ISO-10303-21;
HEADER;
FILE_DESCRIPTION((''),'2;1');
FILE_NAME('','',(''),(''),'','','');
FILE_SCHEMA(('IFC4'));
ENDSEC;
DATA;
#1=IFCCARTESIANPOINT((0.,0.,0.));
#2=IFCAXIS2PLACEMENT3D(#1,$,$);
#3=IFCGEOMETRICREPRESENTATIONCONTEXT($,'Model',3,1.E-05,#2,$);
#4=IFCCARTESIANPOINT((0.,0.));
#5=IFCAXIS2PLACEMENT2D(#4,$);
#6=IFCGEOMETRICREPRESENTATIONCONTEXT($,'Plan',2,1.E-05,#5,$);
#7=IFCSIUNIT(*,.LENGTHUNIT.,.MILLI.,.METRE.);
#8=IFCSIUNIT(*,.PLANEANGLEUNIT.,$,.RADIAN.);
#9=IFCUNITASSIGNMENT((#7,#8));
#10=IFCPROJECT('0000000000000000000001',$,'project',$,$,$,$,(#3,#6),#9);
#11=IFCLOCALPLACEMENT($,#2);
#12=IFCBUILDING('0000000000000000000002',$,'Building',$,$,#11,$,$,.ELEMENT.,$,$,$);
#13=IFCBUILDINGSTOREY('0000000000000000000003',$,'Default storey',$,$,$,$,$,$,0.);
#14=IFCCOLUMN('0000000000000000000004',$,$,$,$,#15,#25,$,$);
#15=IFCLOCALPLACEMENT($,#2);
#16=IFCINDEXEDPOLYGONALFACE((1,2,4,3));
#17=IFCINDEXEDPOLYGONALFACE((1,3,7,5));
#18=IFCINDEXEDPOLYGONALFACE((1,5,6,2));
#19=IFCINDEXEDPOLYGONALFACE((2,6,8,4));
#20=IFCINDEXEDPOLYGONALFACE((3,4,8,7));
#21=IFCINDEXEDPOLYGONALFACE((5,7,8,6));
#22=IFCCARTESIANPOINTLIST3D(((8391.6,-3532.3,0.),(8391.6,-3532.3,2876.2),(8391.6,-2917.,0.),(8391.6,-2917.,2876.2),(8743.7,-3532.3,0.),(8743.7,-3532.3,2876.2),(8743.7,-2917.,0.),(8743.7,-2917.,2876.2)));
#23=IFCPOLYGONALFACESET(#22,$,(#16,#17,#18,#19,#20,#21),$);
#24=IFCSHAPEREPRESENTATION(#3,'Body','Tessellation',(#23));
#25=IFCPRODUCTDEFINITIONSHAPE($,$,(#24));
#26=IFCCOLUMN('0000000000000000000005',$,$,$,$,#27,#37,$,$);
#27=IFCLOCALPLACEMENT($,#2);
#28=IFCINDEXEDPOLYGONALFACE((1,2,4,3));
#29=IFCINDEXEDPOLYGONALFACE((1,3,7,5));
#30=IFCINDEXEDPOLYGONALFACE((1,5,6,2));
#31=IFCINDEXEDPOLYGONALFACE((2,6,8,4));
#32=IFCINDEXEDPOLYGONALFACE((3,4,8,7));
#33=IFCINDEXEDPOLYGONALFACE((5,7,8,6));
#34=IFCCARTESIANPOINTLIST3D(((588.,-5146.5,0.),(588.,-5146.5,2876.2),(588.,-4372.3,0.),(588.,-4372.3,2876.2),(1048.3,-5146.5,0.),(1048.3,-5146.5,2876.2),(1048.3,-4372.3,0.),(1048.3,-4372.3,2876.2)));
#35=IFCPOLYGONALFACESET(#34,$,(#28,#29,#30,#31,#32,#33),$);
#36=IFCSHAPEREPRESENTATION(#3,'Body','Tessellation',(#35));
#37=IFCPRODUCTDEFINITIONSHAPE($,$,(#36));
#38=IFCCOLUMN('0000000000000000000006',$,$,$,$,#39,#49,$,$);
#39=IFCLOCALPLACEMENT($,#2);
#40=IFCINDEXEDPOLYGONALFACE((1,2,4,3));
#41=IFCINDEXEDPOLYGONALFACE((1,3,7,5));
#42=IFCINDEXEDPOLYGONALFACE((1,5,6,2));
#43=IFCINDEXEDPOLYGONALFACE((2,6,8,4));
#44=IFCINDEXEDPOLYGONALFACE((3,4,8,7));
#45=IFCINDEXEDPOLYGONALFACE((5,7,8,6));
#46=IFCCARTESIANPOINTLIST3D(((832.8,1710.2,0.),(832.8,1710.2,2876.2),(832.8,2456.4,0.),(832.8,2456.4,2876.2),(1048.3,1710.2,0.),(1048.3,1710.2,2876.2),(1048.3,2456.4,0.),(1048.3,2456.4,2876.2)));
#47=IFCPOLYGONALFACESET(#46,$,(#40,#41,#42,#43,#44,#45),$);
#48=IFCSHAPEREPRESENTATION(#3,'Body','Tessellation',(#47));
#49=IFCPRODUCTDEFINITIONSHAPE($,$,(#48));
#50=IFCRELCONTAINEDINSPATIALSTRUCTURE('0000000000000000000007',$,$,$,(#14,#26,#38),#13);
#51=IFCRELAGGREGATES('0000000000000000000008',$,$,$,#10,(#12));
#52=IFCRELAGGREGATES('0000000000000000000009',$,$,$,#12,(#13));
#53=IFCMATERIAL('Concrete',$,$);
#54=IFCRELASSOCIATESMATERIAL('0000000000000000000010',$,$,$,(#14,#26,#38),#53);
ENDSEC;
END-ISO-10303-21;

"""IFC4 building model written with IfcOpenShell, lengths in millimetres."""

from ifc_helpers import new_model, si_unit, frame, origin, origin_2d, place, context, project, spatial, rectangle, extrude, material, element, save


model = new_model("IFC4")

# Units and contexts
model_context = context("Model", 3, precision=1e-05, world=origin())
plan_context = context("Plan", 2, precision=1e-05, world=origin_2d())
ifc_project = project(units=[si_unit("LENGTHUNIT", "METRE", prefix="MILLI"), si_unit("PLANEANGLEUNIT", "RADIAN")], contexts=[model_context, plan_context])

# Building, storey
placement = place(None, origin())
building = spatial("IfcBuilding", under=ifc_project, at=placement, Name="Building", CompositionType="ELEMENT")
storey = spatial("IfcBuildingStorey", under=building, Name="Default storey", Elevation=0.0)

# Columns
ifc_material_1 = material(Name="Concrete")
element("IfcColumn", 1, at=placement, inside=storey, material=ifc_material_1, context=model_context, shape_type="SweptSolid", body=[
    extrude(rectangle(XDim=352.1, YDim=615.2, at=origin_2d()), frame((8567.6, -3224.7, 0.0), z_axis=(0.0, 0.0, 1.0), x_axis=(1000.0, 0.0, 0.0)), (0.0, 0.0, 1.0), 2876.2),
])
element("IfcColumn", 2, at=placement, inside=storey, material=ifc_material_1, context=model_context, shape_type="SweptSolid", body=[
    extrude(rectangle(XDim=460.3, YDim=774.2, at=origin_2d()), frame((818.1, -4759.4, 0.0), z_axis=(0.0, 0.0, 1.0), x_axis=(1000.0, 0.0, 0.0)), (0.0, 0.0, 1.0), 2876.2),
])
element("IfcColumn", 3, at=placement, inside=storey, material=ifc_material_1, context=model_context, shape_type="SweptSolid", body=[
    extrude(rectangle(XDim=215.4, YDim=746.2, at=origin_2d()), frame((940.6, 2083.3, 0.0), z_axis=(0.0, 0.0, 1.0), x_axis=(1000.0, 0.0, 0.0)), (0.0, 0.0, 1.0), 2876.2),
])

save(model, "model.ifc")
